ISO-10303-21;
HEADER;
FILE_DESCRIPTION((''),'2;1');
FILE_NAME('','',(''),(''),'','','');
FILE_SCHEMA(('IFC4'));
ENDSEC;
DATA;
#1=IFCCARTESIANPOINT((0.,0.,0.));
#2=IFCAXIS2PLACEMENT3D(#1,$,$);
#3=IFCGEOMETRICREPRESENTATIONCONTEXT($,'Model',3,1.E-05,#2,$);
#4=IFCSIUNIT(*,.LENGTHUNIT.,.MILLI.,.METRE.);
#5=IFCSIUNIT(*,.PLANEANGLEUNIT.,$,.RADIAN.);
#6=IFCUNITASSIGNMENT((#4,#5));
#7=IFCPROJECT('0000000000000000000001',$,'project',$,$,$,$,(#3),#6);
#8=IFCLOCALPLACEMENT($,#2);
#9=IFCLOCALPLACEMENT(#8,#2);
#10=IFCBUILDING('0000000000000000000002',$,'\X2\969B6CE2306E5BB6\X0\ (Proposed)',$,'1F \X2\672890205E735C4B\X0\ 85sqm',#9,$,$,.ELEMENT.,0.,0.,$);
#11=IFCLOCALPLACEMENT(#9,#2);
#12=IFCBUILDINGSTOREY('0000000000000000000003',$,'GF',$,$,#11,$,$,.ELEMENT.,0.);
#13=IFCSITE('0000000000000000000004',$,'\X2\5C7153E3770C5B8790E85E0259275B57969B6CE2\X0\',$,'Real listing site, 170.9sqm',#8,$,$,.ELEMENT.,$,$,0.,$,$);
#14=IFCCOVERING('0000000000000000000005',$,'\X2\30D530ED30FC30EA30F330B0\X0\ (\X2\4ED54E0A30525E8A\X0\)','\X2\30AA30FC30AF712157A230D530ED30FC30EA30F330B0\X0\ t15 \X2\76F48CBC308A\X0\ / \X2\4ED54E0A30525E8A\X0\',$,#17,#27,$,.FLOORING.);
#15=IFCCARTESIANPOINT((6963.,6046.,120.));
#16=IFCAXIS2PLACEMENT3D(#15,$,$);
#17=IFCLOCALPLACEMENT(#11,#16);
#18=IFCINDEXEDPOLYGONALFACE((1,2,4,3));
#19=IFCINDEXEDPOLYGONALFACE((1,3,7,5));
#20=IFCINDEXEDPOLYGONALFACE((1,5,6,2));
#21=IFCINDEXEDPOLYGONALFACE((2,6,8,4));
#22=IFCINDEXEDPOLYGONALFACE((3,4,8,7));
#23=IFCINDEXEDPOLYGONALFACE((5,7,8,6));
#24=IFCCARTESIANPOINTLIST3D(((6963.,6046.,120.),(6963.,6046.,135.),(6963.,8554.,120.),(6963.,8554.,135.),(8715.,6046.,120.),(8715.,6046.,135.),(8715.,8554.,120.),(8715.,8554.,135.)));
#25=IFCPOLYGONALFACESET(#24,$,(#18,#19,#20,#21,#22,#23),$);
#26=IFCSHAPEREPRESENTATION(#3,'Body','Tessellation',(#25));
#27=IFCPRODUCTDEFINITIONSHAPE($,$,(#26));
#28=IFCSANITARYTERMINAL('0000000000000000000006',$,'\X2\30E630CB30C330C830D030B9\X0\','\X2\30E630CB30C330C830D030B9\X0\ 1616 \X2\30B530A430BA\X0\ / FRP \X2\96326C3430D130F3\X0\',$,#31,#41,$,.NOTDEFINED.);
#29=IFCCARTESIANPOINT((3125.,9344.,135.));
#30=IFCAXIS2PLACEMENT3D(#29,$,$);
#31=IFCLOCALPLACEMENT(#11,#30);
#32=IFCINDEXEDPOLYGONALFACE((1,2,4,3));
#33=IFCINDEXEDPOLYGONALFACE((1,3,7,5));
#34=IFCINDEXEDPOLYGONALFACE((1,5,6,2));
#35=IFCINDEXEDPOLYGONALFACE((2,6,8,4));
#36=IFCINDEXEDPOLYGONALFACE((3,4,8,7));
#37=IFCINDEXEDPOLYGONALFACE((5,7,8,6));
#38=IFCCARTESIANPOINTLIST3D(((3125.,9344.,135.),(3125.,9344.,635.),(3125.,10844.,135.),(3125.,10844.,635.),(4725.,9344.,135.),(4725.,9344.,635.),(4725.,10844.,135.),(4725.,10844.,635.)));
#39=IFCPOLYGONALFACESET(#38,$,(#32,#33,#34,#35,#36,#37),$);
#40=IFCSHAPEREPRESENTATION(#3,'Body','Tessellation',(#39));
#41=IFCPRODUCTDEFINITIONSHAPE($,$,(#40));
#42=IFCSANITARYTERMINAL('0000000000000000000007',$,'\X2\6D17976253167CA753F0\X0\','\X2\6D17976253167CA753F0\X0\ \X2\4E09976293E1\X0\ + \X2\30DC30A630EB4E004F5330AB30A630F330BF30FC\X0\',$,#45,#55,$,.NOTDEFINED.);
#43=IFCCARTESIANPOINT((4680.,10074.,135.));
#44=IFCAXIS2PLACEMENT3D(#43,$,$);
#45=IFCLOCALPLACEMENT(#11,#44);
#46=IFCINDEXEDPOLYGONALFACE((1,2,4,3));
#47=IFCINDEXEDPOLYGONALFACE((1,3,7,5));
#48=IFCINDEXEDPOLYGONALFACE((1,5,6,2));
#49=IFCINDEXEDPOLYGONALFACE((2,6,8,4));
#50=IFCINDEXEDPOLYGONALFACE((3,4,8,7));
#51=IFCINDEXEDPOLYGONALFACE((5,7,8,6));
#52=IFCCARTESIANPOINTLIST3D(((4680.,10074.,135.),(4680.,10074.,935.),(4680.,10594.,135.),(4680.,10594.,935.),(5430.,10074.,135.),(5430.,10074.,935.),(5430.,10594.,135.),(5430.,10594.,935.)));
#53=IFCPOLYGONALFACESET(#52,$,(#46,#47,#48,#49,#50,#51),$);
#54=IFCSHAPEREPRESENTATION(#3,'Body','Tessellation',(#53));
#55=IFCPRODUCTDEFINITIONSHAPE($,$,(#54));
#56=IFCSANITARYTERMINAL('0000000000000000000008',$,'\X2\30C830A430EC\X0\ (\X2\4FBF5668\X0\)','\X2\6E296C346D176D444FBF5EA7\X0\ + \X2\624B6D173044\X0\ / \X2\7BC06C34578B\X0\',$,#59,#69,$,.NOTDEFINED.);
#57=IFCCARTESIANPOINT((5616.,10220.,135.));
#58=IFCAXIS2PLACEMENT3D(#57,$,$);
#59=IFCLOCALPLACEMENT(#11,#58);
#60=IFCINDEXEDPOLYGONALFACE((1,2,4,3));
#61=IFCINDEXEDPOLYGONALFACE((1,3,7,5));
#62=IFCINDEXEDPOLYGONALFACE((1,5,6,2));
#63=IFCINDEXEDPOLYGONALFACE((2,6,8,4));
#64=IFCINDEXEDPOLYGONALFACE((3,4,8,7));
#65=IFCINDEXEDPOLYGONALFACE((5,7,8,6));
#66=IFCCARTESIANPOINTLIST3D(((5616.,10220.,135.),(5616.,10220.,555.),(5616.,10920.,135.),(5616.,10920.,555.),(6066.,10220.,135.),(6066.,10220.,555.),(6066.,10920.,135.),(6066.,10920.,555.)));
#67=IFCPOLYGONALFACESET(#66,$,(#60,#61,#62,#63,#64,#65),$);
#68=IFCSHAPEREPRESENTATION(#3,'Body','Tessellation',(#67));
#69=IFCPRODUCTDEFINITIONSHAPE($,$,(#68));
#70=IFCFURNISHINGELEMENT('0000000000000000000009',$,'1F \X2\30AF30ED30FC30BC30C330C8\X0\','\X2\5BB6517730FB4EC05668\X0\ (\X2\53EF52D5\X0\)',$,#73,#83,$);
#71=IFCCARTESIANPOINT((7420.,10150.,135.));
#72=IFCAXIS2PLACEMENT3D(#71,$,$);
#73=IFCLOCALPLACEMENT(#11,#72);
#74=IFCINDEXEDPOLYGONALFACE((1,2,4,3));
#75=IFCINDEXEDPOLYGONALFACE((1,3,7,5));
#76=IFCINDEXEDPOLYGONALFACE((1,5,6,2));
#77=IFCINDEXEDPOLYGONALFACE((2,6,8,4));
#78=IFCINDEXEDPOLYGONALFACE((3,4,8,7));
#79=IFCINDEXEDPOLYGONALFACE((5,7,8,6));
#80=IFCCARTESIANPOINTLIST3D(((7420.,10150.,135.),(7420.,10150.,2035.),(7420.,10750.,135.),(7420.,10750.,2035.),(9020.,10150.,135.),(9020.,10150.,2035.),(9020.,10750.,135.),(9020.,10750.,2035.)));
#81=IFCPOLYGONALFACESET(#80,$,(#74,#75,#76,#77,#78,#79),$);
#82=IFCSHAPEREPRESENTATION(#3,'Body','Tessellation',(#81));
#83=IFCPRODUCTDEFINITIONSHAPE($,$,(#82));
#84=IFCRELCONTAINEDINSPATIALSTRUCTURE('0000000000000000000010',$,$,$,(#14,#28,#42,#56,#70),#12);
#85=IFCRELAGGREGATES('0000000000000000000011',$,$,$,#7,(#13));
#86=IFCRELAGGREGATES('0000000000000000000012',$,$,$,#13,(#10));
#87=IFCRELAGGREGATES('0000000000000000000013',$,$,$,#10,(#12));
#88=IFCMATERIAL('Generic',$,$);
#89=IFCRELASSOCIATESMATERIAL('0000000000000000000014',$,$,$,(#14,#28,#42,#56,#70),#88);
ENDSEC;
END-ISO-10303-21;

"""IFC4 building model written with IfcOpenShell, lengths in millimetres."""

from ifc_helpers import new_model, si_unit, frame, frame_2d, origin, place, context, project, spatial, rectangle, extrude, material, element, save


model = new_model("IFC4")

# Units and contexts
model_context = context("Model", 3, precision=1e-05, world=origin())
ifc_project = project(units=[si_unit("LENGTHUNIT", "METRE", prefix="MILLI"), si_unit("PLANEANGLEUNIT", "RADIAN")], contexts=[model_context])

# Site, building, storey
site_placement = place(None, origin())
site = spatial("IfcSite", under=ifc_project, at=site_placement, Name="山口県宇部市大字際波", ObjectType="Real listing site, 170.9sqm", CompositionType="ELEMENT", RefElevation=0.0)
building_placement = place(site_placement, origin())
building = spatial("IfcBuilding", under=site, at=building_placement, Name="際波の家 (Proposed)", ObjectType="1F 木造平屋 85sqm", CompositionType="ELEMENT", ElevationOfRefHeight=0.0, ElevationOfTerrain=0.0)
storey_placement = place(building_placement, origin())
storey = spatial("IfcBuildingStorey", under=building, at=storey_placement, Name="GF", CompositionType="ELEMENT", Elevation=0.0)

# Covering
ifc_material_1 = material(Name="Generic")
covering_1_placement = place(storey_placement, frame((6963.0, 6046.0, 120.0)))
element("IfcCovering", 1, at=covering_1_placement, inside=storey, material=ifc_material_1, Name="フローリング (仕上げ床)", Description="オーク無垢フローリング t15 直貼り / 仕上げ床", PredefinedType="FLOORING", context=model_context, shape_type="SweptSolid", body=[
    extrude(rectangle(XDim=1752.0, YDim=2508.0, at=frame_2d((876.0, 1254.0))), frame((6963.0, 6046.0, 120.0)), (0.0, 0.0, 1.0), 15.0),
])

# Sanitary terminals
sanitary_terminal_1_placement = place(storey_placement, frame((3125.0, 9344.0, 135.0)))
element("IfcSanitaryTerminal", 2, at=sanitary_terminal_1_placement, inside=storey, material=ifc_material_1, Name="ユニットバス", Description="ユニットバス 1616 サイズ / FRP 防水パン", PredefinedType="NOTDEFINED", context=model_context, shape_type="SweptSolid", body=[
    extrude(rectangle(XDim=1600.0, YDim=1500.0, at=frame_2d((800.0, 750.0))), frame((3125.0, 9344.0, 135.0)), (0.0, 0.0, 1.0), 500.0),
])
sanitary_terminal_2_placement = place(storey_placement, frame((4680.0, 10074.0, 135.0)))
element("IfcSanitaryTerminal", 3, at=sanitary_terminal_2_placement, inside=storey, material=ifc_material_1, Name="洗面化粧台", Description="洗面化粧台 三面鏡 + ボウル一体カウンター", PredefinedType="NOTDEFINED", context=model_context, shape_type="SweptSolid", body=[
    extrude(rectangle(XDim=750.0, YDim=520.0, at=frame_2d((375.0, 260.0))), frame((4680.0, 10074.0, 135.0)), (0.0, 0.0, 1.0), 800.0),
])
sanitary_terminal_3_placement = place(storey_placement, frame((5616.0, 10220.0, 135.0)))
element("IfcSanitaryTerminal", 4, at=sanitary_terminal_3_placement, inside=storey, material=ifc_material_1, Name="トイレ (便器)", Description="温水洗浄便座 + 手洗い / 節水型", PredefinedType="NOTDEFINED", context=model_context, shape_type="SweptSolid", body=[
    extrude(rectangle(XDim=450.0, YDim=700.0, at=frame_2d((225.0, 350.0))), frame((5616.0, 10220.0, 135.0)), (0.0, 0.0, 1.0), 420.0),
])

# Furnishing element
furnishing_placement = place(storey_placement, frame((7420.0, 10150.0, 135.0)))
element("IfcFurnishingElement", 5, at=furnishing_placement, inside=storey, material=ifc_material_1, Name="1F クローゼット", Description="家具・什器 (可動)", context=model_context, shape_type="SweptSolid", body=[
    extrude(rectangle(XDim=1600.0, YDim=600.0, at=frame_2d((800.0, 300.0))), frame((7420.0, 10150.0, 135.0)), (0.0, 0.0, 1.0), 1900.0),
])

save(model, "model.ifc")
